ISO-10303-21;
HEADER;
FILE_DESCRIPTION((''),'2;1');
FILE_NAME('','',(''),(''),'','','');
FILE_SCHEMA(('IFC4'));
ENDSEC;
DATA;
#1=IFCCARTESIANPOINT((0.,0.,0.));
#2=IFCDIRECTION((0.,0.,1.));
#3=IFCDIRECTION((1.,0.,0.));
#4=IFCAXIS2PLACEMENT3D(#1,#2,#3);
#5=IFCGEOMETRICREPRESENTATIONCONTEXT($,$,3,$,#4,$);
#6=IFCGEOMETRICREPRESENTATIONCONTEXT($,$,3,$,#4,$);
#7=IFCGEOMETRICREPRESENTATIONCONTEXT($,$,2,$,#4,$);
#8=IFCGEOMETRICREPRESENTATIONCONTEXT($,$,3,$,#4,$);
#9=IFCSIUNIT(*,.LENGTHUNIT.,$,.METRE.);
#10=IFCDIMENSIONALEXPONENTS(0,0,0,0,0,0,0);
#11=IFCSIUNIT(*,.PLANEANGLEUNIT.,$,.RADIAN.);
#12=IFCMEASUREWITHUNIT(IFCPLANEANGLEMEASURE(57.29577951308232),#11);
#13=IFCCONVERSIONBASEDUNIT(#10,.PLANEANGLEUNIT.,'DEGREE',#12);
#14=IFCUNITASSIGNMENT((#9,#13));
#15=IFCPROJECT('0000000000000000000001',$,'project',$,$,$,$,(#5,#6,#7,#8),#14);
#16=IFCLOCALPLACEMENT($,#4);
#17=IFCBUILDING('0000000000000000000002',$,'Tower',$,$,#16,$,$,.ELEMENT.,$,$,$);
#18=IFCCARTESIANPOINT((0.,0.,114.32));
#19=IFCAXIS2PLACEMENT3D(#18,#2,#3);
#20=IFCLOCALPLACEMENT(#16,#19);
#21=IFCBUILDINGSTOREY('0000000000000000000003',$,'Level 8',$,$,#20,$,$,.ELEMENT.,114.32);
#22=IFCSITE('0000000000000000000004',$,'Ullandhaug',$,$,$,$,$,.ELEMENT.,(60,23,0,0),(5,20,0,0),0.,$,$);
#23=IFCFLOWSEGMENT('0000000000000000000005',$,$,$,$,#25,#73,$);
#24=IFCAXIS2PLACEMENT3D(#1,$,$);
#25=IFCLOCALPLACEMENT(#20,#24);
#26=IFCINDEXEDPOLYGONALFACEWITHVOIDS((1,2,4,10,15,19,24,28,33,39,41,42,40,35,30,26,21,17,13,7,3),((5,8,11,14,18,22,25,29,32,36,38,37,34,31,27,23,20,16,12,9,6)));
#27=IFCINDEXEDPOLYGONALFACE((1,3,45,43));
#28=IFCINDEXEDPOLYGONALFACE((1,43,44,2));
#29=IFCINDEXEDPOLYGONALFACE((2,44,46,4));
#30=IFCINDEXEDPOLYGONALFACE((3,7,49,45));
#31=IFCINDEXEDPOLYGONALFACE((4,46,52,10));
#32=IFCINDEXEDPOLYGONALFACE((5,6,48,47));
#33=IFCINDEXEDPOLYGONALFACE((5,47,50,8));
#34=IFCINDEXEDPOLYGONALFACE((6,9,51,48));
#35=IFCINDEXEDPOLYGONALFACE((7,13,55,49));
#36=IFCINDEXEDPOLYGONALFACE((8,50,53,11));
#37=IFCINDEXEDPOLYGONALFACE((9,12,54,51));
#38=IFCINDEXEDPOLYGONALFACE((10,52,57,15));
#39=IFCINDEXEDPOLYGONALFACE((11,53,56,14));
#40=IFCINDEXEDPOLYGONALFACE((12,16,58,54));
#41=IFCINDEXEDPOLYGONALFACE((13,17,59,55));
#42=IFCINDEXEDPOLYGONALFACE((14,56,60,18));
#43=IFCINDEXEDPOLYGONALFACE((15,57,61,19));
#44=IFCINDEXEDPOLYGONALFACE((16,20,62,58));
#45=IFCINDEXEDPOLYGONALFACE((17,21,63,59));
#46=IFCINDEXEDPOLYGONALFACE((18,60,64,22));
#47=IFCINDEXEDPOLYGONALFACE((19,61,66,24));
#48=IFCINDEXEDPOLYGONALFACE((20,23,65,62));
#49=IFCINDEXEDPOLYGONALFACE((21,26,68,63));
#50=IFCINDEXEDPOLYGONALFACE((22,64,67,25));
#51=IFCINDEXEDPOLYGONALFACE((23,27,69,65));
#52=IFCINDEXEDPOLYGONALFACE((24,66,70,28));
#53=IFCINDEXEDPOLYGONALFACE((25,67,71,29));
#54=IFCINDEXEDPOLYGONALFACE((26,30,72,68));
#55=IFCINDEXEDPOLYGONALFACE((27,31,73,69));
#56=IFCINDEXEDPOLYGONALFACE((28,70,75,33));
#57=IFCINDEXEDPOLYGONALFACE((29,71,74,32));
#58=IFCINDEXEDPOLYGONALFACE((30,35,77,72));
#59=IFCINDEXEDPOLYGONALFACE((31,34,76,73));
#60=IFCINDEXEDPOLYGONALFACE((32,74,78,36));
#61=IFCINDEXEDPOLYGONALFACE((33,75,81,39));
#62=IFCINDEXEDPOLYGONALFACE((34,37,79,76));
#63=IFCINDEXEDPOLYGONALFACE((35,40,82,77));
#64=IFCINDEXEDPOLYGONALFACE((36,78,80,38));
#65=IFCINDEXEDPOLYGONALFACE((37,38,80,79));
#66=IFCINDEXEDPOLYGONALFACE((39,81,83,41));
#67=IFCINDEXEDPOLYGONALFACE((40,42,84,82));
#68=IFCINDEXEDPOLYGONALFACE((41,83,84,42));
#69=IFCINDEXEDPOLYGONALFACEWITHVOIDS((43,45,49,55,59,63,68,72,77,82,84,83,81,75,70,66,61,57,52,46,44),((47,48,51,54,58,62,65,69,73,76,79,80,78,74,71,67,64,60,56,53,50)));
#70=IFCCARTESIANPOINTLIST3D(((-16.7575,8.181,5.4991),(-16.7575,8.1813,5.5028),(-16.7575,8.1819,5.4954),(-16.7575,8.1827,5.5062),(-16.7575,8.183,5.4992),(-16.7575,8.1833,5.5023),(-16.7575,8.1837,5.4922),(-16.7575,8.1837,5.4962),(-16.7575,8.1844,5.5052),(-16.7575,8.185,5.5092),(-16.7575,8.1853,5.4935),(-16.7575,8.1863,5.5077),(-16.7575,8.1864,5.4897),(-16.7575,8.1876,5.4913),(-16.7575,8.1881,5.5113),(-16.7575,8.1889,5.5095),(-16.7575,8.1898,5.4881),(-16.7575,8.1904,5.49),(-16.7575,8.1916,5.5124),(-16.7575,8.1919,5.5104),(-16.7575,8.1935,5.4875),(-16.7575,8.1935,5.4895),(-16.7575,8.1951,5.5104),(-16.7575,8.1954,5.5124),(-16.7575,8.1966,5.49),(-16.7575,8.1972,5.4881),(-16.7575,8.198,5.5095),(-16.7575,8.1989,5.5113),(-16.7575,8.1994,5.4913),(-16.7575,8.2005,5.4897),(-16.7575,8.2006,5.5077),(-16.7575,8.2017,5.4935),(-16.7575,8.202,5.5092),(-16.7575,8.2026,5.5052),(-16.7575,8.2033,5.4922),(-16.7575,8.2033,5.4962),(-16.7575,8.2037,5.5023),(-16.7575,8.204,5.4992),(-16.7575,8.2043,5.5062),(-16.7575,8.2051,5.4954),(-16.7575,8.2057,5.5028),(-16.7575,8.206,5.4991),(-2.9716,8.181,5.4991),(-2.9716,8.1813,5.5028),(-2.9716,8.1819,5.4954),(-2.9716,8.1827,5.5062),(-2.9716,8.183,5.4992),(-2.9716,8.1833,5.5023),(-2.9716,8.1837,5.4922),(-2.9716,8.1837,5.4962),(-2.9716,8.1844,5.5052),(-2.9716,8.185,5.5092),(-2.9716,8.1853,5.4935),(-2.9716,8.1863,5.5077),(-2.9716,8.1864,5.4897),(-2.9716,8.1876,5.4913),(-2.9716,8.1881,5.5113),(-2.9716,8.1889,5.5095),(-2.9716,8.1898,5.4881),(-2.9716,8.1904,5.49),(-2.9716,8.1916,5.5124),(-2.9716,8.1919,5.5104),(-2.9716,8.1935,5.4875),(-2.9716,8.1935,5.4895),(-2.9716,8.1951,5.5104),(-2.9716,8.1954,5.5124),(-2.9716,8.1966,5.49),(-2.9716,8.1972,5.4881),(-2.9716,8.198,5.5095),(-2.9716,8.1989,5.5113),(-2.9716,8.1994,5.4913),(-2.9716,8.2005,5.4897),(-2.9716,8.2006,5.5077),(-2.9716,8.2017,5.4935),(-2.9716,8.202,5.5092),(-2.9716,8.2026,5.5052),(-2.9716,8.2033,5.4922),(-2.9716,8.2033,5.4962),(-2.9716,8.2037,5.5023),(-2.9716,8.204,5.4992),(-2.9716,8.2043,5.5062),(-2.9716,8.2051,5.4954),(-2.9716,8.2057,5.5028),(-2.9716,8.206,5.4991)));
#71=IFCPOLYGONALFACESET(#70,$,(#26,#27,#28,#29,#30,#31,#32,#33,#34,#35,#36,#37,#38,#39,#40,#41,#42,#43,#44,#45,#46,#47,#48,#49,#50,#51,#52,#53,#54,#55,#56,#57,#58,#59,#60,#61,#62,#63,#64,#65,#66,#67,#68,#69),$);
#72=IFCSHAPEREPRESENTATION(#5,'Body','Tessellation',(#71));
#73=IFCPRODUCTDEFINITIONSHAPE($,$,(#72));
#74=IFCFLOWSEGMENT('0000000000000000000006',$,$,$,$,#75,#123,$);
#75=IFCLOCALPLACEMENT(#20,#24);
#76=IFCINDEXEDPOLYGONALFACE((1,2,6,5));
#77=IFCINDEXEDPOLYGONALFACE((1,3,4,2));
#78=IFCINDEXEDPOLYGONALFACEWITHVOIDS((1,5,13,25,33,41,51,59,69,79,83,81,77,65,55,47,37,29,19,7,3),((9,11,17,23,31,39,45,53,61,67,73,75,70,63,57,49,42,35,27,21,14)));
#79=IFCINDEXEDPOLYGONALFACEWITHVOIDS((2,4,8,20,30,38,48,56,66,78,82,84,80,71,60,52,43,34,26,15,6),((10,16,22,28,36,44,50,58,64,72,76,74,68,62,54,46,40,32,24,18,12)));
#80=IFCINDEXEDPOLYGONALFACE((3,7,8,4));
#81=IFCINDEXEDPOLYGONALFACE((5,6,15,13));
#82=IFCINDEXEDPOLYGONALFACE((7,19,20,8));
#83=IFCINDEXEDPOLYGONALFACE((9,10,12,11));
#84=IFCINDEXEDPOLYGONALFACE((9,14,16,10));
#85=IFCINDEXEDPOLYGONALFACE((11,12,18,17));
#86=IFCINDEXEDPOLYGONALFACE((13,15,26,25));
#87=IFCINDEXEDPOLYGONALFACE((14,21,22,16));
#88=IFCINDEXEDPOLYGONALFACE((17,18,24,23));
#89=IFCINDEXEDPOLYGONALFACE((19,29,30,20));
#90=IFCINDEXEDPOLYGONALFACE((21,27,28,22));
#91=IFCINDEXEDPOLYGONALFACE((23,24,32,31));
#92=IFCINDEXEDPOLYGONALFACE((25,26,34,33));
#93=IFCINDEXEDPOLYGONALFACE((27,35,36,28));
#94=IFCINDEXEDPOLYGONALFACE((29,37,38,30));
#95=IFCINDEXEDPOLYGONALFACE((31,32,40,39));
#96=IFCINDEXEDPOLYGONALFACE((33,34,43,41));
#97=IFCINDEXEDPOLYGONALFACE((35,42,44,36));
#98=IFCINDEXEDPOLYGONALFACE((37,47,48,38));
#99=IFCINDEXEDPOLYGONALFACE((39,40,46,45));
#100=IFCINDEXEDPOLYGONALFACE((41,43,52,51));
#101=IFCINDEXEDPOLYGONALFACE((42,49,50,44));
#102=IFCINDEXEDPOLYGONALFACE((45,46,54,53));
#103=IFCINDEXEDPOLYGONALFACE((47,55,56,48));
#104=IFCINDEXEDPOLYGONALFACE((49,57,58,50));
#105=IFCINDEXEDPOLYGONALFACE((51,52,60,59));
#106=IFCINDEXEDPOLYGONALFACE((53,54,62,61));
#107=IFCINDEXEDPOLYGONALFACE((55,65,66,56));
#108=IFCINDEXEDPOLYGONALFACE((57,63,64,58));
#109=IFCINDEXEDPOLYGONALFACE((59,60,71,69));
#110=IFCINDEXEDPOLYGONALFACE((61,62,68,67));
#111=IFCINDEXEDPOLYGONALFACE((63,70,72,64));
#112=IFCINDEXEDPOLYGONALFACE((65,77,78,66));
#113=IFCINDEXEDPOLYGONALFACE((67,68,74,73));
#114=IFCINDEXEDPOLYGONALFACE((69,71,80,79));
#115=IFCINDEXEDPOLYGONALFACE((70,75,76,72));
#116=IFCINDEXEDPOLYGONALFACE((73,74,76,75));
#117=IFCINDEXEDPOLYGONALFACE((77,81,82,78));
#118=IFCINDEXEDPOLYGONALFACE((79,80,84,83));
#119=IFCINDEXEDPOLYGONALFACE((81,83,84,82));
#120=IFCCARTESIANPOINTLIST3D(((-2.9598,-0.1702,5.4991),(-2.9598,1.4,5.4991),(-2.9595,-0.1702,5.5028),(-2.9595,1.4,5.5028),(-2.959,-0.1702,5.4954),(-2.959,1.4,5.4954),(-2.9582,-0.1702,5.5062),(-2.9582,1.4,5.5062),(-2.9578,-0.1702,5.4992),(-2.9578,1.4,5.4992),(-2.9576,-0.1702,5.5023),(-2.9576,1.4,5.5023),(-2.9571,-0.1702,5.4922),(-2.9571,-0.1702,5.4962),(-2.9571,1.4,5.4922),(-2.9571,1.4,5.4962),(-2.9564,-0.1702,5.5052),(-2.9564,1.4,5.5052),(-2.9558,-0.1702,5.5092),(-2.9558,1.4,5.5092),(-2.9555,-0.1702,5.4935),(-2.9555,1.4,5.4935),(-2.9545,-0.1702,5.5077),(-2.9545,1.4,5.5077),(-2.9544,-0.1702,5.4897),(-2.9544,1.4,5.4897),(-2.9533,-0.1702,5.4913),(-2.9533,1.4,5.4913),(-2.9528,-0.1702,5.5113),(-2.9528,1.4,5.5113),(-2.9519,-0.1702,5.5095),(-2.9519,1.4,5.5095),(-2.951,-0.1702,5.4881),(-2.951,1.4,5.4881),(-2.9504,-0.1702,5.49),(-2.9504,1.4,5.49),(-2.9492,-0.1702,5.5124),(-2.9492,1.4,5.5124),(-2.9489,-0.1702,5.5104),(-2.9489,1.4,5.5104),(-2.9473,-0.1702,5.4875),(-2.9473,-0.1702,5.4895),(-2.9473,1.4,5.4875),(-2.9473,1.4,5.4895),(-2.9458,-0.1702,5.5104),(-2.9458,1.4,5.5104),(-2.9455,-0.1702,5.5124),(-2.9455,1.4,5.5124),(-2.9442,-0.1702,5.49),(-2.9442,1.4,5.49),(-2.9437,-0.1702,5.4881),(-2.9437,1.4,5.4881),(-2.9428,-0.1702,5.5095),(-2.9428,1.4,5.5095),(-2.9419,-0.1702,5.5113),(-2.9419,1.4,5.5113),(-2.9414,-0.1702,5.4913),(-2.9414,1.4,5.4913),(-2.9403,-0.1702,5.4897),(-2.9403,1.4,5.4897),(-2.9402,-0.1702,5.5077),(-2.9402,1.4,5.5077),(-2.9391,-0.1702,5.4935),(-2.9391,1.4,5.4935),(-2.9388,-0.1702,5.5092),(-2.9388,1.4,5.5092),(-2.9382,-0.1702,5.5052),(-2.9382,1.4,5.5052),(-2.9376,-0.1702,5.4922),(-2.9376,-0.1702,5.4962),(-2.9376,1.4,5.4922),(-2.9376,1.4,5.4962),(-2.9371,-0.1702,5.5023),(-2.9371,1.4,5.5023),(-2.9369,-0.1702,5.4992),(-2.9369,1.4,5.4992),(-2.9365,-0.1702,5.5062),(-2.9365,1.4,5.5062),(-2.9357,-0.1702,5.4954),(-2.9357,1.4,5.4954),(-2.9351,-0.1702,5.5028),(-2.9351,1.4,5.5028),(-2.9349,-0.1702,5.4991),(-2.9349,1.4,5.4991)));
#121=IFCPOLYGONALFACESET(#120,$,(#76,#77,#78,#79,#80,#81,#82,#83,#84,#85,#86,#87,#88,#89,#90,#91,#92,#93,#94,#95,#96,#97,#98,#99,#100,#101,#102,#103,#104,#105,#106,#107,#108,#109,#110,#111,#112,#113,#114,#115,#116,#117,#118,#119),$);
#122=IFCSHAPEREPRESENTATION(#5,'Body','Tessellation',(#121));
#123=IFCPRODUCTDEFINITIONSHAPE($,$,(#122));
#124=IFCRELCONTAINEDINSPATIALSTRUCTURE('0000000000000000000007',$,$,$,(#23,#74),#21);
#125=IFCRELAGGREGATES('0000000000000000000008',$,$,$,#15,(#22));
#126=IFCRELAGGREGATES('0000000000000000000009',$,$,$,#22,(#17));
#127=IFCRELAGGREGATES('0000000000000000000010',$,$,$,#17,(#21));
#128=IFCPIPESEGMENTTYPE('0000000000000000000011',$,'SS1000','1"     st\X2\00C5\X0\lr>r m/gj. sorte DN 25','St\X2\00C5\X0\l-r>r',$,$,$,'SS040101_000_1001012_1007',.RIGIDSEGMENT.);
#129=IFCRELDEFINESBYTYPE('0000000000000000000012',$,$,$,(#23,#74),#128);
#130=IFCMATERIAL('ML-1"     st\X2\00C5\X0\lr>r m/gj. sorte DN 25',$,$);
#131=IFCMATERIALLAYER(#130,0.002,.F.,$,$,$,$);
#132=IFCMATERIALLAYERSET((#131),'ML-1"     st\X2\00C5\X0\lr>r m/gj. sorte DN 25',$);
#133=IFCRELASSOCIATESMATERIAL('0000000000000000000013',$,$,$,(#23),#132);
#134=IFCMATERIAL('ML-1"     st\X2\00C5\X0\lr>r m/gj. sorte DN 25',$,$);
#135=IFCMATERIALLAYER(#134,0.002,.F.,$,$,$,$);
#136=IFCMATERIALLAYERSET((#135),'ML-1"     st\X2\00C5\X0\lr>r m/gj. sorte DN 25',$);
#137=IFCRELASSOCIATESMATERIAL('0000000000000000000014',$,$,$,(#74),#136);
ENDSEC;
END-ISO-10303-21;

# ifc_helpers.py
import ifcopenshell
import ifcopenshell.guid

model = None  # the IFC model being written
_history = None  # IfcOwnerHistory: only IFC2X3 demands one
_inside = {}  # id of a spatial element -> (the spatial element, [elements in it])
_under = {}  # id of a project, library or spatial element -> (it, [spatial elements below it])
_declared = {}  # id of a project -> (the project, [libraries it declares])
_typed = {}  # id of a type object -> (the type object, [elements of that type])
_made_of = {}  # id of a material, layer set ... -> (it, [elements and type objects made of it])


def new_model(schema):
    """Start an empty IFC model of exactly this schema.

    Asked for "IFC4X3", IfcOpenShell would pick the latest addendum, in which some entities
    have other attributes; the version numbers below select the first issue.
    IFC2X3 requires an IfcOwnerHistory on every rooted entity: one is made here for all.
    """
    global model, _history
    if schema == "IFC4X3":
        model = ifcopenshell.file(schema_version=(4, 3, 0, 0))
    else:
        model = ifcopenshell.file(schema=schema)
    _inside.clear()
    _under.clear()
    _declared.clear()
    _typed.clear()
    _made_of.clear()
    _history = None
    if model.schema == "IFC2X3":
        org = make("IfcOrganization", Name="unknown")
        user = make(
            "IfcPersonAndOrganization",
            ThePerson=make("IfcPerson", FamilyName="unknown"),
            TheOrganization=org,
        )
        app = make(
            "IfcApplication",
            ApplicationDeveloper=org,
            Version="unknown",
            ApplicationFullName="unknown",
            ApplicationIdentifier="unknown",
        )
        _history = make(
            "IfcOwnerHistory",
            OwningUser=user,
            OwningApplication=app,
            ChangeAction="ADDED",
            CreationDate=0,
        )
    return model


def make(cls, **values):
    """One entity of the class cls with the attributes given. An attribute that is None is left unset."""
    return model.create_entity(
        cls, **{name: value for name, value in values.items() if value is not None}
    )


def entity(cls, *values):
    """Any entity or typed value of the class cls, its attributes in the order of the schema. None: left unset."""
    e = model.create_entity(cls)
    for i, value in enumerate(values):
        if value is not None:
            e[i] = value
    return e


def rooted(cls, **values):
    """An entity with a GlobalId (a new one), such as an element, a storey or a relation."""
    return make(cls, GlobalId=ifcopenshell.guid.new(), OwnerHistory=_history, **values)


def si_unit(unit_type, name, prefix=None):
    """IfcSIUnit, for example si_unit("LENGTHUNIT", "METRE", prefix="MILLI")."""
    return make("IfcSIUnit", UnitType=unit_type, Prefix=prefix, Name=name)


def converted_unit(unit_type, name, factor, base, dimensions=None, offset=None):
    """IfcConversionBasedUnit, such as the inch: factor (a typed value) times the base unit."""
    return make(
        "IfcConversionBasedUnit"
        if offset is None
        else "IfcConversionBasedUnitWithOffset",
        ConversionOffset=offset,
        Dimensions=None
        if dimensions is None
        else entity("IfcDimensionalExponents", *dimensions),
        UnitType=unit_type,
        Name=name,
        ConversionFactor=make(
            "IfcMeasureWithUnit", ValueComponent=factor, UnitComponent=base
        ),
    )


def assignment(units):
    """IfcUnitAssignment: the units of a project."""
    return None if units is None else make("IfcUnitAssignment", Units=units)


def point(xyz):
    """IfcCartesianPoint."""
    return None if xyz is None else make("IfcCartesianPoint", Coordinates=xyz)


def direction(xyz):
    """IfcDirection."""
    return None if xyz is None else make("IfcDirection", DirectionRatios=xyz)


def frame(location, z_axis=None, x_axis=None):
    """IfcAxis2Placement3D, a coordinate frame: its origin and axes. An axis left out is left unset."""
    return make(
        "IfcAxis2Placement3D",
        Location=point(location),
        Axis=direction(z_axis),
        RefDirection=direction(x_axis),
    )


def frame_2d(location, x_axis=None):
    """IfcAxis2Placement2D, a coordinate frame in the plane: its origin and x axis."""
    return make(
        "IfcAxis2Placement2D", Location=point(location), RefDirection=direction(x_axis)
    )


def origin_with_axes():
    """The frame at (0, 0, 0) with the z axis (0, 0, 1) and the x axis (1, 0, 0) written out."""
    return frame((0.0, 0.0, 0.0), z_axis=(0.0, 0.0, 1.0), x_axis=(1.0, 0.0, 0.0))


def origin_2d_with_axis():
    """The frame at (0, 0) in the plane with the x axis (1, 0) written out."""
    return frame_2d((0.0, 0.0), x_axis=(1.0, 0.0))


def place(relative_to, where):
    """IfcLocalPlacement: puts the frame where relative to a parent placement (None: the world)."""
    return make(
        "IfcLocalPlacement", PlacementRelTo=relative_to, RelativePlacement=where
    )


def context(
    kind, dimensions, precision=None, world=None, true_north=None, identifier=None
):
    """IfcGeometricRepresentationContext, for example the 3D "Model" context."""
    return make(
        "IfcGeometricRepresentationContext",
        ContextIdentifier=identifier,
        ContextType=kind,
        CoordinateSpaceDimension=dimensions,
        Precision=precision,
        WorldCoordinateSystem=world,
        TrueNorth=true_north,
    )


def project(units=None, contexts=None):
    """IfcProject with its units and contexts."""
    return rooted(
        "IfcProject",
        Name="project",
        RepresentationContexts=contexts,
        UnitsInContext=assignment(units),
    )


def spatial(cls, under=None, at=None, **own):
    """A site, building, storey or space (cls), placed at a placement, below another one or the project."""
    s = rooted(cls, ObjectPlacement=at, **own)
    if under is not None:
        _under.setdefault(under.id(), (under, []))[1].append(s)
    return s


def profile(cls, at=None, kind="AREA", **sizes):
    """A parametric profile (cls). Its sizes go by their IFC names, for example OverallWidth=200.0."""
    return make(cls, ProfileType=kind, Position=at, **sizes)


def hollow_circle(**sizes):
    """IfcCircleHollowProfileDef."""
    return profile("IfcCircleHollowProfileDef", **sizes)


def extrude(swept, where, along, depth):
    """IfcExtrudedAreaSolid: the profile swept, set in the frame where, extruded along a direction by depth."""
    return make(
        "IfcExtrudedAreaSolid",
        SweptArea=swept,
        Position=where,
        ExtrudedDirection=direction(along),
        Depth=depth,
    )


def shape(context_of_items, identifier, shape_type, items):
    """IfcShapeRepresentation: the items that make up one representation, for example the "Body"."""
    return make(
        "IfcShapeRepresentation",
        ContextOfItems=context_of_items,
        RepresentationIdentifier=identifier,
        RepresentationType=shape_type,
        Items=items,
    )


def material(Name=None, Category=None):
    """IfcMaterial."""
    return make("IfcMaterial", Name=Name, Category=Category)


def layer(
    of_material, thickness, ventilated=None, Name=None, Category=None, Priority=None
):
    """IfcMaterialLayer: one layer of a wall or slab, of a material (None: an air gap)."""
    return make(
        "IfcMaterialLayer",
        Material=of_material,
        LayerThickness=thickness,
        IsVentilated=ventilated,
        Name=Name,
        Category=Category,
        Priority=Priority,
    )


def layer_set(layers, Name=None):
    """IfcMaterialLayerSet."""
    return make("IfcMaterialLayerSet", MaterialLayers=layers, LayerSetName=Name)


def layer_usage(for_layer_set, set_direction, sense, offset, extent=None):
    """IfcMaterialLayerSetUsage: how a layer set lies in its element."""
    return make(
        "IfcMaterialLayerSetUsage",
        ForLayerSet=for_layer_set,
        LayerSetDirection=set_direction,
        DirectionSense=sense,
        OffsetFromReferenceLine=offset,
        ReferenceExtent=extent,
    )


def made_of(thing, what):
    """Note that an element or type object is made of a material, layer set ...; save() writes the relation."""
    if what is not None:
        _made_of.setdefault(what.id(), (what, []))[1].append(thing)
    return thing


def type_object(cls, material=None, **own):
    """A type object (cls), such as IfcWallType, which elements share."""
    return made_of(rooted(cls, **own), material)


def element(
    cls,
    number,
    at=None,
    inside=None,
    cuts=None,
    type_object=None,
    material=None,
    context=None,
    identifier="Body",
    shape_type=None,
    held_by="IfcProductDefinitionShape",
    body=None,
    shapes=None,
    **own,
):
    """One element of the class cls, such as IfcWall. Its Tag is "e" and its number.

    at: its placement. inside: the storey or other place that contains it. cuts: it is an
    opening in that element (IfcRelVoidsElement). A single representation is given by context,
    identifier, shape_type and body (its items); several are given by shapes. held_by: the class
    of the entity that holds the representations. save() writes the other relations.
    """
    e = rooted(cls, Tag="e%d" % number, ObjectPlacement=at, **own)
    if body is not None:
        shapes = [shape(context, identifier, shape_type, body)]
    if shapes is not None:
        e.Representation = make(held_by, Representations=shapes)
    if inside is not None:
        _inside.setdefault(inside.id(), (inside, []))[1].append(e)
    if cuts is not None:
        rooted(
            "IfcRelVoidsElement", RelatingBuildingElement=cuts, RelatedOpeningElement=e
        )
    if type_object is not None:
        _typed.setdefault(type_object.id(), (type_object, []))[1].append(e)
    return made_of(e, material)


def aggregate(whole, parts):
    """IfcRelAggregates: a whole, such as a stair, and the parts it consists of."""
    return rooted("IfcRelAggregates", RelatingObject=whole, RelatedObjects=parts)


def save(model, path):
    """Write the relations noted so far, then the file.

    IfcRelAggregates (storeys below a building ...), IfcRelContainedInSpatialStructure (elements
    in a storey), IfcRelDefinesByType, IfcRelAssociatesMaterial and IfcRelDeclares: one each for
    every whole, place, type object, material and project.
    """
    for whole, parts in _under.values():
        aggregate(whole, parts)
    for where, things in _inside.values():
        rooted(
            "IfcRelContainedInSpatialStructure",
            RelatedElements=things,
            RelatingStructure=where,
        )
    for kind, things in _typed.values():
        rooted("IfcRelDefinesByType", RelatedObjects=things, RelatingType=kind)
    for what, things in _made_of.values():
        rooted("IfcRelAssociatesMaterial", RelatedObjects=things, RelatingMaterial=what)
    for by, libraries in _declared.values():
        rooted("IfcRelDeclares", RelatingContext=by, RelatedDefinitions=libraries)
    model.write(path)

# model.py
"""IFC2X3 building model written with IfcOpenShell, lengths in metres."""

from ifc_helpers import new_model, entity, si_unit, converted_unit, frame, origin_with_axes, origin_2d_with_axis, place, context, project, spatial, hollow_circle, extrude, material, layer, layer_set, layer_usage, type_object, element, save


model = new_model("IFC2X3")

# Units and contexts
context_of_model_1 = context(None, 3, world=origin_with_axes())
context_of_model_2 = context(None, 3, world=origin_with_axes())
context_of_model_3 = context(None, 2, world=origin_with_axes())
context_of_model_4 = context(None, 3, world=origin_with_axes())
ifc_project = project(units=[si_unit("LENGTHUNIT", "METRE"), converted_unit("PLANEANGLEUNIT", "DEGREE", entity("IfcPlaneAngleMeasure", 57.29577951308232), si_unit("PLANEANGLEUNIT", "RADIAN"), dimensions=[0, 0, 0, 0, 0, 0, 0])], contexts=[context_of_model_1, context_of_model_2, context_of_model_3, context_of_model_4])

# Site, building, storey
site = spatial("IfcSite", under=ifc_project, Name="Ullandhaug", CompositionType="ELEMENT", RefLatitude=(60, 23, 0, 0), RefLongitude=(5, 20, 0, 0), RefElevation=0.0)
building_placement = place(None, origin_with_axes())
building = spatial("IfcBuilding", under=site, at=building_placement, Name="Tower", CompositionType="ELEMENT")
storey_placement = place(building_placement, frame((0.0, 0.0, 114.32), z_axis=(0.0, 0.0, 1.0), x_axis=(1.0, 0.0, 0.0)))
storey = spatial("IfcBuildingStorey", under=building, at=storey_placement, Name="Level 8", CompositionType="ELEMENT", Elevation=114.32)

# Flow segments
pipe_segment_type_1 = type_object("IfcPipeSegmentType", Name="SS1000", Description="1\"     stÅlr>r m/gj. sorte DN 25", ApplicableOccurrence="StÅl-r>r", ElementType="SS040101_000_1001012_1007", PredefinedType="RIGIDSEGMENT")
ifc_material_1 = material(Name="ML-1\"     stÅlr>r m/gj. sorte DN 25")
ifc_layer_1 = layer(ifc_material_1, 0.002, ventilated=False)
ifc_layer_set_1 = layer_set([ifc_layer_1], Name="ML-1\"     stÅlr>r m/gj. sorte DN 25")
ifc_layer_usage_1 = layer_usage(ifc_layer_set_1, "AXIS2", "POSITIVE", 0.0)
flow_segment_1_placement = place(storey_placement, frame((-2.9716, 8.1935, 5.5), z_axis=(-1.0, 0.0, 0.0), x_axis=(0.0, 0.0, -1.0)))
element("IfcFlowSegment", 1, at=flow_segment_1_placement, inside=storey, type_object=pipe_segment_type_1, material=ifc_layer_usage_1, context=context_of_model_1, shape_type="SweptSolid", body=[
    extrude(hollow_circle(Radius=0.0125, WallThickness=0.002, at=origin_2d_with_axis()), origin_with_axes(), (0.0, 0.0, 1.0), 13.7859),
])
ifc_material_2 = material(Name="ML-1\"     stÅlr>r m/gj. sorte DN 25")
ifc_layer_2 = layer(ifc_material_2, 0.002, ventilated=False)
ifc_layer_set_2 = layer_set([ifc_layer_2], Name="ML-1\"     stÅlr>r m/gj. sorte DN 25")
ifc_layer_usage_2 = layer_usage(ifc_layer_set_2, "AXIS2", "POSITIVE", 0.0)
flow_segment_2_placement = place(storey_placement, frame((-2.9473, -0.1702, 5.5), z_axis=(0.0, 1.0, 0.0), x_axis=(0.0, 0.0, -1.0)))
element("IfcFlowSegment", 2, at=flow_segment_2_placement, inside=storey, type_object=pipe_segment_type_1, material=ifc_layer_usage_2, context=context_of_model_1, shape_type="SweptSolid", body=[
    extrude(hollow_circle(Radius=0.0125, WallThickness=0.002, at=origin_2d_with_axis()), origin_with_axes(), (0.0, 0.0, 1.0), 1.5702),
])

save(model, "model.ifc")
